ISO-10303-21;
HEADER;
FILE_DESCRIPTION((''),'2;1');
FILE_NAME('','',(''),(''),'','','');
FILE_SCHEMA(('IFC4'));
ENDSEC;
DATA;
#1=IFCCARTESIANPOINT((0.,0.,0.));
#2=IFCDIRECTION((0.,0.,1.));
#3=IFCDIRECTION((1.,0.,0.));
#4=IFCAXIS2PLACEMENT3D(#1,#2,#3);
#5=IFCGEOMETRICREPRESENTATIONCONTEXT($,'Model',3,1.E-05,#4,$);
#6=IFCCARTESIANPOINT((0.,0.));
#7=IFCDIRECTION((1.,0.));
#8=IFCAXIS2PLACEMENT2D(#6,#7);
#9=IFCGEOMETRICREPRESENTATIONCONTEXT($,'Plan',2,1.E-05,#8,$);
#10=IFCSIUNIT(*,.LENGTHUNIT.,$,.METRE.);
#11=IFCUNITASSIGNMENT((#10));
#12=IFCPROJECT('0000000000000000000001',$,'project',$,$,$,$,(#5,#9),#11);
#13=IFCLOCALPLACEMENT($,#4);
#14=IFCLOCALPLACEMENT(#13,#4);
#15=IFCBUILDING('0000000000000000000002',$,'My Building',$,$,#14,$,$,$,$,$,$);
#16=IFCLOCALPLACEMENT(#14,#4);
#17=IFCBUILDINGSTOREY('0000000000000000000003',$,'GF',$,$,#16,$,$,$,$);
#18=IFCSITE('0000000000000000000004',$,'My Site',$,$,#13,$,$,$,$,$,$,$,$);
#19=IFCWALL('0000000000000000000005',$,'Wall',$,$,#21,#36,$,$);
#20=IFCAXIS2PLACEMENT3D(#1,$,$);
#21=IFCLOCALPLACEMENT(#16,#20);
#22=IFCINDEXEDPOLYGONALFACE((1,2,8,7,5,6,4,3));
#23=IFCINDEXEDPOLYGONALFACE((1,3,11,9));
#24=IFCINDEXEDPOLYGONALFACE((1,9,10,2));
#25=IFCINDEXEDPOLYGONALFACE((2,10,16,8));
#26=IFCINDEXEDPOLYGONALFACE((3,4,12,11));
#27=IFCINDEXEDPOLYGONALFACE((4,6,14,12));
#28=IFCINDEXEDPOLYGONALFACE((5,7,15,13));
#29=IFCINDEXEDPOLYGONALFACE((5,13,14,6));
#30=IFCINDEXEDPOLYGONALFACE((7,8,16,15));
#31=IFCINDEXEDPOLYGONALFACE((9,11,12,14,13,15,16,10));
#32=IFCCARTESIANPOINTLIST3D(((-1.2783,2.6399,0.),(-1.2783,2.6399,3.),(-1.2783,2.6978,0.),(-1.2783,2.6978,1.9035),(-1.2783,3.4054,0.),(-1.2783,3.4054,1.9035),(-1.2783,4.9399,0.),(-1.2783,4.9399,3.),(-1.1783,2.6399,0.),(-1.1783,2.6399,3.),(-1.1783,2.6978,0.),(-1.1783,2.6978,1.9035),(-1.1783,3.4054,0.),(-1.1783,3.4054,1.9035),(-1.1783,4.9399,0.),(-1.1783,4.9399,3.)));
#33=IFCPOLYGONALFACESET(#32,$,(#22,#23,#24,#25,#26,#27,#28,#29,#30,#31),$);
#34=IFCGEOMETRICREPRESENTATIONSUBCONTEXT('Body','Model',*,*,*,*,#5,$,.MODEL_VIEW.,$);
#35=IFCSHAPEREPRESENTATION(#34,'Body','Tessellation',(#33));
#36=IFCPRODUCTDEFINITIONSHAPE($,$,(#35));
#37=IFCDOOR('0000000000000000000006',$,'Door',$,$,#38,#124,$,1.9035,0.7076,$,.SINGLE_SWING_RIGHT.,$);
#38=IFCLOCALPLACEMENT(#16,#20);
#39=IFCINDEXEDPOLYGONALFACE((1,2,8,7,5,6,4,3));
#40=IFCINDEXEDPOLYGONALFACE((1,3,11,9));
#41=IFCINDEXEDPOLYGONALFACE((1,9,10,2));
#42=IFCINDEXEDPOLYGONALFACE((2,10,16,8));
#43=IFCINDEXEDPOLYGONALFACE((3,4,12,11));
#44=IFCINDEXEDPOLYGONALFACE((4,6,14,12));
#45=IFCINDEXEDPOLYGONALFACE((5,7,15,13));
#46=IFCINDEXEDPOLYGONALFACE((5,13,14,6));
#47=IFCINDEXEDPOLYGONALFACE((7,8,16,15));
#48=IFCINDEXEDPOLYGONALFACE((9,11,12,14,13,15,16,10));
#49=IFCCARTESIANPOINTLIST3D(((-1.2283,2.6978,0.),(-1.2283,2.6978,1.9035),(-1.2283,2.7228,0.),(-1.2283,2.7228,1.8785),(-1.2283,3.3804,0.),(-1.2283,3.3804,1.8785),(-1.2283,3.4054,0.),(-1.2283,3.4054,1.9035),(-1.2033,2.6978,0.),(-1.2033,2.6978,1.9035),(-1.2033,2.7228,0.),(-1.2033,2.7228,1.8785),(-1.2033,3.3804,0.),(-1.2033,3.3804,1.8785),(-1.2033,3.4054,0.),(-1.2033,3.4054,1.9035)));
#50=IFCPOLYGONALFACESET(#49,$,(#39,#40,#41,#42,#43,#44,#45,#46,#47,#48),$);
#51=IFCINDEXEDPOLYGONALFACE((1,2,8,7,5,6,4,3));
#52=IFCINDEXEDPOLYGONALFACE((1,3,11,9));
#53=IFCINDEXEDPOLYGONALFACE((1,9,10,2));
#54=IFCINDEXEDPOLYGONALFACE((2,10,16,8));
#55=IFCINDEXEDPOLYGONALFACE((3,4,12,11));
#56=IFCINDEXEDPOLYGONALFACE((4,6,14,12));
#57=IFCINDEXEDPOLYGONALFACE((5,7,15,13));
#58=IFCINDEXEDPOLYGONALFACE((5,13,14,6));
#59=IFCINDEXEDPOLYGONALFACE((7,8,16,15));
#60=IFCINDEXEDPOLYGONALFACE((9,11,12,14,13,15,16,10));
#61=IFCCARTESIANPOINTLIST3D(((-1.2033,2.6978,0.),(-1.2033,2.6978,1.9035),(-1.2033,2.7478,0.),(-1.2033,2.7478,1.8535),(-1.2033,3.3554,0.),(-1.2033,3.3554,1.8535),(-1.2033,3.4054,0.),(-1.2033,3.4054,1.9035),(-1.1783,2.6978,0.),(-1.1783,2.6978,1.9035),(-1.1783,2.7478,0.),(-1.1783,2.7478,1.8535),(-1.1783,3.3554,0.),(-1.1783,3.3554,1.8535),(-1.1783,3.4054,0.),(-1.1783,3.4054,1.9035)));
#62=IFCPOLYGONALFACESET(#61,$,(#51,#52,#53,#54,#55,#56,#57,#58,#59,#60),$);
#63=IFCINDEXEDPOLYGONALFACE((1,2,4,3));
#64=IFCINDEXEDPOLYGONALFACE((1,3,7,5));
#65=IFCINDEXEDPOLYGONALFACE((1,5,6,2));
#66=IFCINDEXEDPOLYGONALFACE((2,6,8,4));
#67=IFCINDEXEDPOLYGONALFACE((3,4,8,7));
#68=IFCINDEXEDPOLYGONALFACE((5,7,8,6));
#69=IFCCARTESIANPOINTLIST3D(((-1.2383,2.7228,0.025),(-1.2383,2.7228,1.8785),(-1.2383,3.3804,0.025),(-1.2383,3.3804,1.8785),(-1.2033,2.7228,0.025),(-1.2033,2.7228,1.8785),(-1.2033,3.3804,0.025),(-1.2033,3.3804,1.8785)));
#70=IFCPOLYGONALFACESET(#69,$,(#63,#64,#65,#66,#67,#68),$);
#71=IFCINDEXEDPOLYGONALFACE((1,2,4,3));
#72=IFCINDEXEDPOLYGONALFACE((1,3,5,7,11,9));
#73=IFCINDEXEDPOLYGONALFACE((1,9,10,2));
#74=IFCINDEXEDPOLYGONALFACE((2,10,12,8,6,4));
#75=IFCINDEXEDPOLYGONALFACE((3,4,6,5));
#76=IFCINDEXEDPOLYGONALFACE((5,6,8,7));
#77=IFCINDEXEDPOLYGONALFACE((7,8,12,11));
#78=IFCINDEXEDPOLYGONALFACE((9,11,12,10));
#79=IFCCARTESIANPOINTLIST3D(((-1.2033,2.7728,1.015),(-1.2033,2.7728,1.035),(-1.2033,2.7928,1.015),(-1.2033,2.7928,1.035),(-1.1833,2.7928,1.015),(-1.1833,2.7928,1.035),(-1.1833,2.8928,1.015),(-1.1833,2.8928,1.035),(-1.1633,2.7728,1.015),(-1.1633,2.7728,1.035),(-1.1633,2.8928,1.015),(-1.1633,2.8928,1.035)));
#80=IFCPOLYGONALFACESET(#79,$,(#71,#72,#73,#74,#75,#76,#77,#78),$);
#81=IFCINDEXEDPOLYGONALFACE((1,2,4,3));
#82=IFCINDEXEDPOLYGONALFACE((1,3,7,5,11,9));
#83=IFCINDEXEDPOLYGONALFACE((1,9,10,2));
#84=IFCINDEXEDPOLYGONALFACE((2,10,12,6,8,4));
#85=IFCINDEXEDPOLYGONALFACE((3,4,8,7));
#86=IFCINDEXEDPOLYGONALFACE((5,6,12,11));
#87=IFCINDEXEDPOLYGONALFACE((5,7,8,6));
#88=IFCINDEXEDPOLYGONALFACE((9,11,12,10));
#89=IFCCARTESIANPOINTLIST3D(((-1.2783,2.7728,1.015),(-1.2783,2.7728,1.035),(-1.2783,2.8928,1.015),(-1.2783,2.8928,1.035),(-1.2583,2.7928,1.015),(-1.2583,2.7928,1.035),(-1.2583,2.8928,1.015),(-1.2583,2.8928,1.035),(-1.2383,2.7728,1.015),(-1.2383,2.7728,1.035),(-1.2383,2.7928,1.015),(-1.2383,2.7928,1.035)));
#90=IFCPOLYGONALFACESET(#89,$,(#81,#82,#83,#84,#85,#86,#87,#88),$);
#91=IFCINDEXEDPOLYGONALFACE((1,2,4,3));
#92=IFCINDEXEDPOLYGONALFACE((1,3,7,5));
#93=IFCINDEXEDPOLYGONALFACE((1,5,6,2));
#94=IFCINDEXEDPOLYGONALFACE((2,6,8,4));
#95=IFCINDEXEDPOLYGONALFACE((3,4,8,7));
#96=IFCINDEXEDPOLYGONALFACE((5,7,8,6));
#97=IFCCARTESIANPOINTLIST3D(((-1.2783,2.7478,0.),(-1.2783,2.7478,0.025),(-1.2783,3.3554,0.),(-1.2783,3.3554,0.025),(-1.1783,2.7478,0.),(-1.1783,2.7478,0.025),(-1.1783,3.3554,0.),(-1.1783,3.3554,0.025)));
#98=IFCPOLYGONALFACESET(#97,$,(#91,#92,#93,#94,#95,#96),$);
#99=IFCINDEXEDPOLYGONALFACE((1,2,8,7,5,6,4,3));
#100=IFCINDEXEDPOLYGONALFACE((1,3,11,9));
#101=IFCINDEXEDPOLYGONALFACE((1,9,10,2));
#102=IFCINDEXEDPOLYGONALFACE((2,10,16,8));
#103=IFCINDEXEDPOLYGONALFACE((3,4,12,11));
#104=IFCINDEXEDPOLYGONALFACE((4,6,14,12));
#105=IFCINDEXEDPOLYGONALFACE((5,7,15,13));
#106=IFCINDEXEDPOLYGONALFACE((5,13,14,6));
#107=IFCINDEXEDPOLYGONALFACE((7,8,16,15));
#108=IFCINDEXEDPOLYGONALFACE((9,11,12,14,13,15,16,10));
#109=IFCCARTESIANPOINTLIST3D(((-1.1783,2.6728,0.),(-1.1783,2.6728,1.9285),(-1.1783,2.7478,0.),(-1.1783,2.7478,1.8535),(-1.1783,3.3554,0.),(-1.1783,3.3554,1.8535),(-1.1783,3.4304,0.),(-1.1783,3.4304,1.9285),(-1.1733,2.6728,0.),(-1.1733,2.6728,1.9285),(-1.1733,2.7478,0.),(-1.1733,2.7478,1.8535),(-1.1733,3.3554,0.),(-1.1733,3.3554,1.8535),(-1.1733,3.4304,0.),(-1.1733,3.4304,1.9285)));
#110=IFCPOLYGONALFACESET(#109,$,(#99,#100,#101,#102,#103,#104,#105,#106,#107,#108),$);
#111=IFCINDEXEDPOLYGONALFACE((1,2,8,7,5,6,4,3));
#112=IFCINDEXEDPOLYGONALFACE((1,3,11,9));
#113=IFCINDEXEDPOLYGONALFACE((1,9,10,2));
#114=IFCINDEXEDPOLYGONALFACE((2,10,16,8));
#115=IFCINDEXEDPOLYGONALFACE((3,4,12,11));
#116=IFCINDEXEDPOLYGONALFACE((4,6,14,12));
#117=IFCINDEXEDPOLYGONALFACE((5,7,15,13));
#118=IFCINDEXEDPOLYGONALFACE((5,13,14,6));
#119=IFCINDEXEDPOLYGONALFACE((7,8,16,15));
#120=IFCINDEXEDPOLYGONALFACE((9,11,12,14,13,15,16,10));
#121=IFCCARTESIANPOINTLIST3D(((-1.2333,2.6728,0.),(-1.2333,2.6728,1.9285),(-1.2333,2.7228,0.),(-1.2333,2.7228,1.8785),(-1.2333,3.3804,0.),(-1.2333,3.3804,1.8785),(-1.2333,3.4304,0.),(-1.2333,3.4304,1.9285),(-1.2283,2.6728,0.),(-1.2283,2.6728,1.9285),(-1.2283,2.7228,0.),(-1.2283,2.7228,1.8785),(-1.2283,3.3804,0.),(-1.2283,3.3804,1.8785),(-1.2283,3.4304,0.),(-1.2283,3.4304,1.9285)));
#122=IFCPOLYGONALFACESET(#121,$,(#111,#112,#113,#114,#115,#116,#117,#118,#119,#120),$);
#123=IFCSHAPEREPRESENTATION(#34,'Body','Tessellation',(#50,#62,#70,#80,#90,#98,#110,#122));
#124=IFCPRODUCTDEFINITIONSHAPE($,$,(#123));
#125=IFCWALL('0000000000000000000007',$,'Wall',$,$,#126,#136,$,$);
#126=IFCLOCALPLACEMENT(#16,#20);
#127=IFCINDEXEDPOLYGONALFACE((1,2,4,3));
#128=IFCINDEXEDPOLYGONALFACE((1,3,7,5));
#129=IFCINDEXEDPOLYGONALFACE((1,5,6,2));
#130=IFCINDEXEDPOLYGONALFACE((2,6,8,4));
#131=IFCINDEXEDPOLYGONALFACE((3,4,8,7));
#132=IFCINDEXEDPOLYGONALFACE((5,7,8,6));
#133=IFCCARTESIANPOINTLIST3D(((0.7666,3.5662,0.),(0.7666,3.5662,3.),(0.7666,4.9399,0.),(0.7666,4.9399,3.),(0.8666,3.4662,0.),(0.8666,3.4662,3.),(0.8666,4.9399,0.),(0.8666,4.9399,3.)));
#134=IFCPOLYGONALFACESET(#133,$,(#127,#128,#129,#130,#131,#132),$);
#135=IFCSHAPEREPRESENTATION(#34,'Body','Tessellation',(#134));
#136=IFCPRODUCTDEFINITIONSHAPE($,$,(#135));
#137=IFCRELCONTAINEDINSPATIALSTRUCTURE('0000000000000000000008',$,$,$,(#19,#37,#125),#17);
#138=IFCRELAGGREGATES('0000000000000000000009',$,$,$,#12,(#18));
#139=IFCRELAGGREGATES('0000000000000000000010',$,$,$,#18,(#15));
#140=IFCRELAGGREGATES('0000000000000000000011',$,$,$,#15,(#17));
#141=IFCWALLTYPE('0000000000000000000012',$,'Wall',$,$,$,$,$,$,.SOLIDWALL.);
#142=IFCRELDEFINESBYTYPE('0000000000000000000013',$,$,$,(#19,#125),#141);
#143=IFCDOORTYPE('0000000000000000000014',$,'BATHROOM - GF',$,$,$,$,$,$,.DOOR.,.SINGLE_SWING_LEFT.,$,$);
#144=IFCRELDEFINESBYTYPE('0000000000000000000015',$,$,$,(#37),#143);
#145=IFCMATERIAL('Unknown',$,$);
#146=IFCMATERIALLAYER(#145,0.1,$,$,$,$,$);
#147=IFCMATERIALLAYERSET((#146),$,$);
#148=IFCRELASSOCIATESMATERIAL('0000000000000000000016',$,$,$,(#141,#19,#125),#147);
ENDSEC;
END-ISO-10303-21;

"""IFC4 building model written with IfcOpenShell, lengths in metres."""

from ifc_helpers import new_model, entity, si_unit, frame, origin_with_axes, origin_2d_with_axis, place, context, subcontext, project, spatial, line, indexed_curve, outline, extrude, shape, source, transform, mapped, material, layer, layer_set, layer_usage, type_object, type_shapes, element, fill, save


model = new_model("IFC4")

# Units and contexts
model_context = context("Model", 3, precision=1e-05, world=origin_with_axes())
plan_context = context("Plan", 2, precision=1e-05, world=origin_2d_with_axis())
body_context_1 = subcontext(model_context, "Body", "Model", "MODEL_VIEW")
body_context_2 = subcontext(plan_context, "Body", "Plan", "PLAN_VIEW")
ifc_project = project(units=[si_unit("LENGTHUNIT", "METRE")], contexts=[model_context, plan_context])

# Site, building, storey
site_placement = place(None, origin_with_axes())
site = spatial("IfcSite", under=ifc_project, at=site_placement, Name="My Site")
building_placement = place(site_placement, origin_with_axes())
building = spatial("IfcBuilding", under=site, at=building_placement, Name="My Building")
storey_placement = place(building_placement, origin_with_axes())
storey = spatial("IfcBuildingStorey", under=building, at=storey_placement, Name="GF")

# Shared definitions
ifc_material = material(Name="Unknown")

# Shared definitions
ifc_layer_1 = layer(ifc_material, 0.1)
ifc_layer_set_1 = layer_set([ifc_layer_1])
wall_type = type_object("IfcWallType", Name="Wall", PredefinedType="SOLIDWALL", material=ifc_layer_set_1)

# Wall, opening, door
ifc_layer_usage_1 = layer_usage(ifc_layer_set_1, "AXIS2", "POSITIVE", 0.0)
wall_1_placement = place(storey_placement, frame((-1.1783, 2.6399, 0.0), z_axis=(0.0, 0.0, 1.0), x_axis=(0.0, 1.0, 0.0)))
wall_1 = element("IfcWall", 1, at=wall_1_placement, inside=storey, type_object=wall_type, material=ifc_layer_usage_1, Name="Wall", context=body_context_1, shape_type="SweptSolid", body=[
    extrude(outline(indexed_curve([(0.0, 0.0), (0.0, 0.1), (2.3, 0.1), (2.3, 0.0)], segments=[line(1, 2, 3, 4, 1)])), origin_with_axes(), (0.0, 0.0, 1.0), 3.0),
])
shared_shape_1 = source(origin_with_axes(), body_context_1, "Body", "SweptSolid", [
    extrude(outline(indexed_curve([(0.0, 0.0), (0.7076, 0.0), (0.7076, 1.9035), (0.0, 1.9035)], segments=[line(1, 2, 3, 4, 1)])), frame((0.0, -0.6, 0.0), z_axis=(0.0, -1.0, 0.0), x_axis=(1.0, 0.0, 0.0)), (0.0, 0.0, -1.0), 1.2),
])
opening_1_placement = place(wall_1_placement, frame((0.0579, 0.0, 0.0), z_axis=(0.0, 0.0, 1.0), x_axis=(1.0, 0.0, 0.0)))
opening_1 = element("IfcOpeningElement", 2, at=opening_1_placement, cuts=wall_1, PredefinedType="OPENING", context=body_context_1, shape_type="MappedRepresentation", body=[
    mapped(shared_shape_1, transform((0.0, 0.0, 0.0), x_axis=(1.0, 0.0, 0.0), y_axis=(0.0, 1.0, 0.0), z_axis=(0.0, 0.0, 1.0), scale=1.0)),
])
door_type_1 = type_object("IfcDoorType", Name="BATHROOM - GF", OperationType="SINGLE_SWING_LEFT", PredefinedType="DOOR")
shared_shape_2 = source(origin_with_axes(), body_context_1, "Body", "SweptSolid", [
    extrude(outline(indexed_curve([(0.0, 0.0), (0.0, 1.9035), (0.7076, 1.9035), (0.7076, 0.0), (0.6826, 0.0), (0.6826, 1.8785), (0.025, 1.8785), (0.025, 0.0)], segments=[line(1, 2, 3, 4, 5, 6, 7, 8, 1)])), frame((0.0, 0.025, 0.0), z_axis=(0.0, -1.0, 0.0), x_axis=(1.0, 0.0, 0.0)), (0.0, 0.0, -1.0), 0.025),
    extrude(outline(indexed_curve([(0.0, 0.0), (0.0, 1.9035), (0.7076, 1.9035), (0.7076, 0.0), (0.6576, 0.0), (0.6576, 1.8535), (0.05, 1.8535), (0.05, 0.0)], segments=[line(1, 2, 3, 4, 5, 6, 7, 8, 1)])), frame((0.0, 0.0, 0.0), z_axis=(0.0, -1.0, 0.0), x_axis=(1.0, 0.0, 0.0)), (0.0, 0.0, -1.0), 0.025),
    extrude(outline(indexed_curve([(0.0, 0.0), (0.6576, 0.0), (0.6576, 0.035), (0.0, 0.035)], segments=[line(1, 2, 3, 4, 1)])), frame((0.025, 0.025, 0.025), z_axis=(0.0, 0.0, 1.0), x_axis=(1.0, 0.0, 0.0)), (0.0, 0.0, 1.0), 1.8535),
    extrude(outline(indexed_curve([(0.0, 0.0), (0.0, -0.04), (0.12, -0.04), (0.12, -0.02), (0.02, -0.02), (0.02, 0.0)], segments=[line(1, 2, 3, 4, 5, 6, 1)])), frame((0.075, 0.025, 1.015), z_axis=(0.0, 0.0, 1.0), x_axis=(1.0, 0.0, 0.0)), (0.0, 0.0, 1.0), 0.02),
    extrude(outline(indexed_curve([(0.0, 0.0), (0.0, 0.04), (0.12, 0.04), (0.12, 0.02), (0.02, 0.02), (0.02, 0.0)], segments=[line(1, 2, 3, 4, 5, 6, 1)])), frame((0.075, 0.06, 1.015), z_axis=(0.0, 0.0, 1.0), x_axis=(1.0, 0.0, 0.0)), (0.0, 0.0, 1.0), 0.02),
    extrude(outline(indexed_curve([(0.0, 0.0), (0.6076, 0.0), (0.6076, 0.1), (0.0, 0.1)], segments=[line(1, 2, 3, 4, 1)])), frame((0.05, 0.0, 0.0), z_axis=(0.0, 0.0, 1.0), x_axis=(1.0, 0.0, 0.0)), (0.0, 0.0, 1.0), 0.025),
    extrude(outline(indexed_curve([(0.0, 0.0), (0.0, 1.9285), (0.7576, 1.9285), (0.7576, 0.0), (0.6826, 0.0), (0.6826, 1.8535), (0.075, 1.8535), (0.075, 0.0)], segments=[line(1, 2, 3, 4, 5, 6, 7, 8, 1)])), frame((-0.025, -0.005, 0.0), z_axis=(0.0, -1.0, 0.0), x_axis=(1.0, 0.0, 0.0)), (0.0, 0.0, -1.0), 0.005),
    extrude(outline(indexed_curve([(0.0, 0.0), (0.0, 1.9285), (0.7576, 1.9285), (0.7576, 0.0), (0.7076, 0.0), (0.7076, 1.8785), (0.05, 1.8785), (0.05, 0.0)], segments=[line(1, 2, 3, 4, 5, 6, 7, 8, 1)])), frame((-0.025, 0.05, 0.0), z_axis=(0.0, -1.0, 0.0), x_axis=(1.0, 0.0, 0.0)), (0.0, 0.0, -1.0), 0.005),
])
shared_shape_3 = source(origin_with_axes(), body_context_2, "Body", "Curve2D", [
    entity("IfcIndexedPolyCurve", entity("IfcCartesianPointList2D", [[0.0, 0.0], [0.0, 0.05], [0.025, 0.05], [0.025, 0.025], [0.05, 0.025], [0.05, 0.0]]), [entity("IfcLineIndex", [1, 2, 3, 4, 5, 6, 1])]),
    entity("IfcIndexedPolyCurve", entity("IfcCartesianPointList2D", [[0.7076, 0.0], [0.7076, 0.05], [0.6826, 0.05], [0.6826, 0.025], [0.6576, 0.025], [0.6576, 0.0]]), [entity("IfcLineIndex", [1, 2, 3, 4, 5, 6, 1])]),
    entity("IfcTrimmedCurve", entity("IfcEllipse", entity("IfcAxis2Placement2D", entity("IfcCartesianPoint", [0.6476, 0.05]), entity("IfcDirection", [1.0, 0.0])), 0.6226, 0.6576), [entity("IfcCartesianPoint", [0.6476, 0.7076])], [entity("IfcCartesianPoint", [0.025, 0.05])], True, "CARTESIAN"),
    entity("IfcIndexedPolyCurve", entity("IfcCartesianPointList2D", [[0.6826, 0.05], [0.6476, 0.05], [0.6476, 0.7076], [0.6826, 0.7076]]), [entity("IfcLineIndex", [1, 2, 3, 4, 1])]),
])
type_shapes(door_type_1, [shared_shape_2, shared_shape_3])
door_1_placement = place(opening_1_placement, frame((0.0, 0.0, 0.0), z_axis=(0.0, 0.0, 1.0), x_axis=(1.0, 0.0, 0.0)))
door_1 = element("IfcDoor", 3, at=door_1_placement, inside=storey, type_object=door_type_1, Name="Door", OperationType="SINGLE_SWING_RIGHT", OverallHeight=1.9035, OverallWidth=0.7076, shapes=[
    shape(body_context_1, "Body", "MappedRepresentation", [mapped(shared_shape_2, transform((0.0, 0.0, 0.0), x_axis=(1.0, 0.0, 0.0), y_axis=(0.0, 1.0, 0.0), z_axis=(0.0, 0.0, 1.0), scale=1.0))]),
    shape(body_context_2, "Body", "MappedRepresentation", [mapped(shared_shape_3, transform((0.0, 0.0, 0.0), x_axis=(1.0, 0.0, 0.0), y_axis=(0.0, 1.0, 0.0), z_axis=(0.0, 0.0, 1.0), scale=1.0))]),
])
fill(opening_1, door_1)

# Wall
ifc_layer_usage_2 = layer_usage(ifc_layer_set_1, "AXIS2", "POSITIVE", 0.0)
wall_2_placement = place(storey_placement, frame((0.7666, 5.0399, 0.0), z_axis=(0.0, 0.0, 1.0), x_axis=(0.0, -1.0, 0.0)))
element("IfcWall", 4, at=wall_2_placement, inside=storey, type_object=wall_type, material=ifc_layer_usage_2, Name="Wall", context=body_context_1, shape_type="SweptSolid", body=[
    extrude(outline(indexed_curve([(0.1, 0.0), (0.1, 0.1), (1.5737, 0.1), (1.4737, 0.0)], segments=[line(1, 2, 3, 4, 1)])), origin_with_axes(), (0.0, 0.0, 1.0), 3.0),
])

save(model, "model.ifc")
